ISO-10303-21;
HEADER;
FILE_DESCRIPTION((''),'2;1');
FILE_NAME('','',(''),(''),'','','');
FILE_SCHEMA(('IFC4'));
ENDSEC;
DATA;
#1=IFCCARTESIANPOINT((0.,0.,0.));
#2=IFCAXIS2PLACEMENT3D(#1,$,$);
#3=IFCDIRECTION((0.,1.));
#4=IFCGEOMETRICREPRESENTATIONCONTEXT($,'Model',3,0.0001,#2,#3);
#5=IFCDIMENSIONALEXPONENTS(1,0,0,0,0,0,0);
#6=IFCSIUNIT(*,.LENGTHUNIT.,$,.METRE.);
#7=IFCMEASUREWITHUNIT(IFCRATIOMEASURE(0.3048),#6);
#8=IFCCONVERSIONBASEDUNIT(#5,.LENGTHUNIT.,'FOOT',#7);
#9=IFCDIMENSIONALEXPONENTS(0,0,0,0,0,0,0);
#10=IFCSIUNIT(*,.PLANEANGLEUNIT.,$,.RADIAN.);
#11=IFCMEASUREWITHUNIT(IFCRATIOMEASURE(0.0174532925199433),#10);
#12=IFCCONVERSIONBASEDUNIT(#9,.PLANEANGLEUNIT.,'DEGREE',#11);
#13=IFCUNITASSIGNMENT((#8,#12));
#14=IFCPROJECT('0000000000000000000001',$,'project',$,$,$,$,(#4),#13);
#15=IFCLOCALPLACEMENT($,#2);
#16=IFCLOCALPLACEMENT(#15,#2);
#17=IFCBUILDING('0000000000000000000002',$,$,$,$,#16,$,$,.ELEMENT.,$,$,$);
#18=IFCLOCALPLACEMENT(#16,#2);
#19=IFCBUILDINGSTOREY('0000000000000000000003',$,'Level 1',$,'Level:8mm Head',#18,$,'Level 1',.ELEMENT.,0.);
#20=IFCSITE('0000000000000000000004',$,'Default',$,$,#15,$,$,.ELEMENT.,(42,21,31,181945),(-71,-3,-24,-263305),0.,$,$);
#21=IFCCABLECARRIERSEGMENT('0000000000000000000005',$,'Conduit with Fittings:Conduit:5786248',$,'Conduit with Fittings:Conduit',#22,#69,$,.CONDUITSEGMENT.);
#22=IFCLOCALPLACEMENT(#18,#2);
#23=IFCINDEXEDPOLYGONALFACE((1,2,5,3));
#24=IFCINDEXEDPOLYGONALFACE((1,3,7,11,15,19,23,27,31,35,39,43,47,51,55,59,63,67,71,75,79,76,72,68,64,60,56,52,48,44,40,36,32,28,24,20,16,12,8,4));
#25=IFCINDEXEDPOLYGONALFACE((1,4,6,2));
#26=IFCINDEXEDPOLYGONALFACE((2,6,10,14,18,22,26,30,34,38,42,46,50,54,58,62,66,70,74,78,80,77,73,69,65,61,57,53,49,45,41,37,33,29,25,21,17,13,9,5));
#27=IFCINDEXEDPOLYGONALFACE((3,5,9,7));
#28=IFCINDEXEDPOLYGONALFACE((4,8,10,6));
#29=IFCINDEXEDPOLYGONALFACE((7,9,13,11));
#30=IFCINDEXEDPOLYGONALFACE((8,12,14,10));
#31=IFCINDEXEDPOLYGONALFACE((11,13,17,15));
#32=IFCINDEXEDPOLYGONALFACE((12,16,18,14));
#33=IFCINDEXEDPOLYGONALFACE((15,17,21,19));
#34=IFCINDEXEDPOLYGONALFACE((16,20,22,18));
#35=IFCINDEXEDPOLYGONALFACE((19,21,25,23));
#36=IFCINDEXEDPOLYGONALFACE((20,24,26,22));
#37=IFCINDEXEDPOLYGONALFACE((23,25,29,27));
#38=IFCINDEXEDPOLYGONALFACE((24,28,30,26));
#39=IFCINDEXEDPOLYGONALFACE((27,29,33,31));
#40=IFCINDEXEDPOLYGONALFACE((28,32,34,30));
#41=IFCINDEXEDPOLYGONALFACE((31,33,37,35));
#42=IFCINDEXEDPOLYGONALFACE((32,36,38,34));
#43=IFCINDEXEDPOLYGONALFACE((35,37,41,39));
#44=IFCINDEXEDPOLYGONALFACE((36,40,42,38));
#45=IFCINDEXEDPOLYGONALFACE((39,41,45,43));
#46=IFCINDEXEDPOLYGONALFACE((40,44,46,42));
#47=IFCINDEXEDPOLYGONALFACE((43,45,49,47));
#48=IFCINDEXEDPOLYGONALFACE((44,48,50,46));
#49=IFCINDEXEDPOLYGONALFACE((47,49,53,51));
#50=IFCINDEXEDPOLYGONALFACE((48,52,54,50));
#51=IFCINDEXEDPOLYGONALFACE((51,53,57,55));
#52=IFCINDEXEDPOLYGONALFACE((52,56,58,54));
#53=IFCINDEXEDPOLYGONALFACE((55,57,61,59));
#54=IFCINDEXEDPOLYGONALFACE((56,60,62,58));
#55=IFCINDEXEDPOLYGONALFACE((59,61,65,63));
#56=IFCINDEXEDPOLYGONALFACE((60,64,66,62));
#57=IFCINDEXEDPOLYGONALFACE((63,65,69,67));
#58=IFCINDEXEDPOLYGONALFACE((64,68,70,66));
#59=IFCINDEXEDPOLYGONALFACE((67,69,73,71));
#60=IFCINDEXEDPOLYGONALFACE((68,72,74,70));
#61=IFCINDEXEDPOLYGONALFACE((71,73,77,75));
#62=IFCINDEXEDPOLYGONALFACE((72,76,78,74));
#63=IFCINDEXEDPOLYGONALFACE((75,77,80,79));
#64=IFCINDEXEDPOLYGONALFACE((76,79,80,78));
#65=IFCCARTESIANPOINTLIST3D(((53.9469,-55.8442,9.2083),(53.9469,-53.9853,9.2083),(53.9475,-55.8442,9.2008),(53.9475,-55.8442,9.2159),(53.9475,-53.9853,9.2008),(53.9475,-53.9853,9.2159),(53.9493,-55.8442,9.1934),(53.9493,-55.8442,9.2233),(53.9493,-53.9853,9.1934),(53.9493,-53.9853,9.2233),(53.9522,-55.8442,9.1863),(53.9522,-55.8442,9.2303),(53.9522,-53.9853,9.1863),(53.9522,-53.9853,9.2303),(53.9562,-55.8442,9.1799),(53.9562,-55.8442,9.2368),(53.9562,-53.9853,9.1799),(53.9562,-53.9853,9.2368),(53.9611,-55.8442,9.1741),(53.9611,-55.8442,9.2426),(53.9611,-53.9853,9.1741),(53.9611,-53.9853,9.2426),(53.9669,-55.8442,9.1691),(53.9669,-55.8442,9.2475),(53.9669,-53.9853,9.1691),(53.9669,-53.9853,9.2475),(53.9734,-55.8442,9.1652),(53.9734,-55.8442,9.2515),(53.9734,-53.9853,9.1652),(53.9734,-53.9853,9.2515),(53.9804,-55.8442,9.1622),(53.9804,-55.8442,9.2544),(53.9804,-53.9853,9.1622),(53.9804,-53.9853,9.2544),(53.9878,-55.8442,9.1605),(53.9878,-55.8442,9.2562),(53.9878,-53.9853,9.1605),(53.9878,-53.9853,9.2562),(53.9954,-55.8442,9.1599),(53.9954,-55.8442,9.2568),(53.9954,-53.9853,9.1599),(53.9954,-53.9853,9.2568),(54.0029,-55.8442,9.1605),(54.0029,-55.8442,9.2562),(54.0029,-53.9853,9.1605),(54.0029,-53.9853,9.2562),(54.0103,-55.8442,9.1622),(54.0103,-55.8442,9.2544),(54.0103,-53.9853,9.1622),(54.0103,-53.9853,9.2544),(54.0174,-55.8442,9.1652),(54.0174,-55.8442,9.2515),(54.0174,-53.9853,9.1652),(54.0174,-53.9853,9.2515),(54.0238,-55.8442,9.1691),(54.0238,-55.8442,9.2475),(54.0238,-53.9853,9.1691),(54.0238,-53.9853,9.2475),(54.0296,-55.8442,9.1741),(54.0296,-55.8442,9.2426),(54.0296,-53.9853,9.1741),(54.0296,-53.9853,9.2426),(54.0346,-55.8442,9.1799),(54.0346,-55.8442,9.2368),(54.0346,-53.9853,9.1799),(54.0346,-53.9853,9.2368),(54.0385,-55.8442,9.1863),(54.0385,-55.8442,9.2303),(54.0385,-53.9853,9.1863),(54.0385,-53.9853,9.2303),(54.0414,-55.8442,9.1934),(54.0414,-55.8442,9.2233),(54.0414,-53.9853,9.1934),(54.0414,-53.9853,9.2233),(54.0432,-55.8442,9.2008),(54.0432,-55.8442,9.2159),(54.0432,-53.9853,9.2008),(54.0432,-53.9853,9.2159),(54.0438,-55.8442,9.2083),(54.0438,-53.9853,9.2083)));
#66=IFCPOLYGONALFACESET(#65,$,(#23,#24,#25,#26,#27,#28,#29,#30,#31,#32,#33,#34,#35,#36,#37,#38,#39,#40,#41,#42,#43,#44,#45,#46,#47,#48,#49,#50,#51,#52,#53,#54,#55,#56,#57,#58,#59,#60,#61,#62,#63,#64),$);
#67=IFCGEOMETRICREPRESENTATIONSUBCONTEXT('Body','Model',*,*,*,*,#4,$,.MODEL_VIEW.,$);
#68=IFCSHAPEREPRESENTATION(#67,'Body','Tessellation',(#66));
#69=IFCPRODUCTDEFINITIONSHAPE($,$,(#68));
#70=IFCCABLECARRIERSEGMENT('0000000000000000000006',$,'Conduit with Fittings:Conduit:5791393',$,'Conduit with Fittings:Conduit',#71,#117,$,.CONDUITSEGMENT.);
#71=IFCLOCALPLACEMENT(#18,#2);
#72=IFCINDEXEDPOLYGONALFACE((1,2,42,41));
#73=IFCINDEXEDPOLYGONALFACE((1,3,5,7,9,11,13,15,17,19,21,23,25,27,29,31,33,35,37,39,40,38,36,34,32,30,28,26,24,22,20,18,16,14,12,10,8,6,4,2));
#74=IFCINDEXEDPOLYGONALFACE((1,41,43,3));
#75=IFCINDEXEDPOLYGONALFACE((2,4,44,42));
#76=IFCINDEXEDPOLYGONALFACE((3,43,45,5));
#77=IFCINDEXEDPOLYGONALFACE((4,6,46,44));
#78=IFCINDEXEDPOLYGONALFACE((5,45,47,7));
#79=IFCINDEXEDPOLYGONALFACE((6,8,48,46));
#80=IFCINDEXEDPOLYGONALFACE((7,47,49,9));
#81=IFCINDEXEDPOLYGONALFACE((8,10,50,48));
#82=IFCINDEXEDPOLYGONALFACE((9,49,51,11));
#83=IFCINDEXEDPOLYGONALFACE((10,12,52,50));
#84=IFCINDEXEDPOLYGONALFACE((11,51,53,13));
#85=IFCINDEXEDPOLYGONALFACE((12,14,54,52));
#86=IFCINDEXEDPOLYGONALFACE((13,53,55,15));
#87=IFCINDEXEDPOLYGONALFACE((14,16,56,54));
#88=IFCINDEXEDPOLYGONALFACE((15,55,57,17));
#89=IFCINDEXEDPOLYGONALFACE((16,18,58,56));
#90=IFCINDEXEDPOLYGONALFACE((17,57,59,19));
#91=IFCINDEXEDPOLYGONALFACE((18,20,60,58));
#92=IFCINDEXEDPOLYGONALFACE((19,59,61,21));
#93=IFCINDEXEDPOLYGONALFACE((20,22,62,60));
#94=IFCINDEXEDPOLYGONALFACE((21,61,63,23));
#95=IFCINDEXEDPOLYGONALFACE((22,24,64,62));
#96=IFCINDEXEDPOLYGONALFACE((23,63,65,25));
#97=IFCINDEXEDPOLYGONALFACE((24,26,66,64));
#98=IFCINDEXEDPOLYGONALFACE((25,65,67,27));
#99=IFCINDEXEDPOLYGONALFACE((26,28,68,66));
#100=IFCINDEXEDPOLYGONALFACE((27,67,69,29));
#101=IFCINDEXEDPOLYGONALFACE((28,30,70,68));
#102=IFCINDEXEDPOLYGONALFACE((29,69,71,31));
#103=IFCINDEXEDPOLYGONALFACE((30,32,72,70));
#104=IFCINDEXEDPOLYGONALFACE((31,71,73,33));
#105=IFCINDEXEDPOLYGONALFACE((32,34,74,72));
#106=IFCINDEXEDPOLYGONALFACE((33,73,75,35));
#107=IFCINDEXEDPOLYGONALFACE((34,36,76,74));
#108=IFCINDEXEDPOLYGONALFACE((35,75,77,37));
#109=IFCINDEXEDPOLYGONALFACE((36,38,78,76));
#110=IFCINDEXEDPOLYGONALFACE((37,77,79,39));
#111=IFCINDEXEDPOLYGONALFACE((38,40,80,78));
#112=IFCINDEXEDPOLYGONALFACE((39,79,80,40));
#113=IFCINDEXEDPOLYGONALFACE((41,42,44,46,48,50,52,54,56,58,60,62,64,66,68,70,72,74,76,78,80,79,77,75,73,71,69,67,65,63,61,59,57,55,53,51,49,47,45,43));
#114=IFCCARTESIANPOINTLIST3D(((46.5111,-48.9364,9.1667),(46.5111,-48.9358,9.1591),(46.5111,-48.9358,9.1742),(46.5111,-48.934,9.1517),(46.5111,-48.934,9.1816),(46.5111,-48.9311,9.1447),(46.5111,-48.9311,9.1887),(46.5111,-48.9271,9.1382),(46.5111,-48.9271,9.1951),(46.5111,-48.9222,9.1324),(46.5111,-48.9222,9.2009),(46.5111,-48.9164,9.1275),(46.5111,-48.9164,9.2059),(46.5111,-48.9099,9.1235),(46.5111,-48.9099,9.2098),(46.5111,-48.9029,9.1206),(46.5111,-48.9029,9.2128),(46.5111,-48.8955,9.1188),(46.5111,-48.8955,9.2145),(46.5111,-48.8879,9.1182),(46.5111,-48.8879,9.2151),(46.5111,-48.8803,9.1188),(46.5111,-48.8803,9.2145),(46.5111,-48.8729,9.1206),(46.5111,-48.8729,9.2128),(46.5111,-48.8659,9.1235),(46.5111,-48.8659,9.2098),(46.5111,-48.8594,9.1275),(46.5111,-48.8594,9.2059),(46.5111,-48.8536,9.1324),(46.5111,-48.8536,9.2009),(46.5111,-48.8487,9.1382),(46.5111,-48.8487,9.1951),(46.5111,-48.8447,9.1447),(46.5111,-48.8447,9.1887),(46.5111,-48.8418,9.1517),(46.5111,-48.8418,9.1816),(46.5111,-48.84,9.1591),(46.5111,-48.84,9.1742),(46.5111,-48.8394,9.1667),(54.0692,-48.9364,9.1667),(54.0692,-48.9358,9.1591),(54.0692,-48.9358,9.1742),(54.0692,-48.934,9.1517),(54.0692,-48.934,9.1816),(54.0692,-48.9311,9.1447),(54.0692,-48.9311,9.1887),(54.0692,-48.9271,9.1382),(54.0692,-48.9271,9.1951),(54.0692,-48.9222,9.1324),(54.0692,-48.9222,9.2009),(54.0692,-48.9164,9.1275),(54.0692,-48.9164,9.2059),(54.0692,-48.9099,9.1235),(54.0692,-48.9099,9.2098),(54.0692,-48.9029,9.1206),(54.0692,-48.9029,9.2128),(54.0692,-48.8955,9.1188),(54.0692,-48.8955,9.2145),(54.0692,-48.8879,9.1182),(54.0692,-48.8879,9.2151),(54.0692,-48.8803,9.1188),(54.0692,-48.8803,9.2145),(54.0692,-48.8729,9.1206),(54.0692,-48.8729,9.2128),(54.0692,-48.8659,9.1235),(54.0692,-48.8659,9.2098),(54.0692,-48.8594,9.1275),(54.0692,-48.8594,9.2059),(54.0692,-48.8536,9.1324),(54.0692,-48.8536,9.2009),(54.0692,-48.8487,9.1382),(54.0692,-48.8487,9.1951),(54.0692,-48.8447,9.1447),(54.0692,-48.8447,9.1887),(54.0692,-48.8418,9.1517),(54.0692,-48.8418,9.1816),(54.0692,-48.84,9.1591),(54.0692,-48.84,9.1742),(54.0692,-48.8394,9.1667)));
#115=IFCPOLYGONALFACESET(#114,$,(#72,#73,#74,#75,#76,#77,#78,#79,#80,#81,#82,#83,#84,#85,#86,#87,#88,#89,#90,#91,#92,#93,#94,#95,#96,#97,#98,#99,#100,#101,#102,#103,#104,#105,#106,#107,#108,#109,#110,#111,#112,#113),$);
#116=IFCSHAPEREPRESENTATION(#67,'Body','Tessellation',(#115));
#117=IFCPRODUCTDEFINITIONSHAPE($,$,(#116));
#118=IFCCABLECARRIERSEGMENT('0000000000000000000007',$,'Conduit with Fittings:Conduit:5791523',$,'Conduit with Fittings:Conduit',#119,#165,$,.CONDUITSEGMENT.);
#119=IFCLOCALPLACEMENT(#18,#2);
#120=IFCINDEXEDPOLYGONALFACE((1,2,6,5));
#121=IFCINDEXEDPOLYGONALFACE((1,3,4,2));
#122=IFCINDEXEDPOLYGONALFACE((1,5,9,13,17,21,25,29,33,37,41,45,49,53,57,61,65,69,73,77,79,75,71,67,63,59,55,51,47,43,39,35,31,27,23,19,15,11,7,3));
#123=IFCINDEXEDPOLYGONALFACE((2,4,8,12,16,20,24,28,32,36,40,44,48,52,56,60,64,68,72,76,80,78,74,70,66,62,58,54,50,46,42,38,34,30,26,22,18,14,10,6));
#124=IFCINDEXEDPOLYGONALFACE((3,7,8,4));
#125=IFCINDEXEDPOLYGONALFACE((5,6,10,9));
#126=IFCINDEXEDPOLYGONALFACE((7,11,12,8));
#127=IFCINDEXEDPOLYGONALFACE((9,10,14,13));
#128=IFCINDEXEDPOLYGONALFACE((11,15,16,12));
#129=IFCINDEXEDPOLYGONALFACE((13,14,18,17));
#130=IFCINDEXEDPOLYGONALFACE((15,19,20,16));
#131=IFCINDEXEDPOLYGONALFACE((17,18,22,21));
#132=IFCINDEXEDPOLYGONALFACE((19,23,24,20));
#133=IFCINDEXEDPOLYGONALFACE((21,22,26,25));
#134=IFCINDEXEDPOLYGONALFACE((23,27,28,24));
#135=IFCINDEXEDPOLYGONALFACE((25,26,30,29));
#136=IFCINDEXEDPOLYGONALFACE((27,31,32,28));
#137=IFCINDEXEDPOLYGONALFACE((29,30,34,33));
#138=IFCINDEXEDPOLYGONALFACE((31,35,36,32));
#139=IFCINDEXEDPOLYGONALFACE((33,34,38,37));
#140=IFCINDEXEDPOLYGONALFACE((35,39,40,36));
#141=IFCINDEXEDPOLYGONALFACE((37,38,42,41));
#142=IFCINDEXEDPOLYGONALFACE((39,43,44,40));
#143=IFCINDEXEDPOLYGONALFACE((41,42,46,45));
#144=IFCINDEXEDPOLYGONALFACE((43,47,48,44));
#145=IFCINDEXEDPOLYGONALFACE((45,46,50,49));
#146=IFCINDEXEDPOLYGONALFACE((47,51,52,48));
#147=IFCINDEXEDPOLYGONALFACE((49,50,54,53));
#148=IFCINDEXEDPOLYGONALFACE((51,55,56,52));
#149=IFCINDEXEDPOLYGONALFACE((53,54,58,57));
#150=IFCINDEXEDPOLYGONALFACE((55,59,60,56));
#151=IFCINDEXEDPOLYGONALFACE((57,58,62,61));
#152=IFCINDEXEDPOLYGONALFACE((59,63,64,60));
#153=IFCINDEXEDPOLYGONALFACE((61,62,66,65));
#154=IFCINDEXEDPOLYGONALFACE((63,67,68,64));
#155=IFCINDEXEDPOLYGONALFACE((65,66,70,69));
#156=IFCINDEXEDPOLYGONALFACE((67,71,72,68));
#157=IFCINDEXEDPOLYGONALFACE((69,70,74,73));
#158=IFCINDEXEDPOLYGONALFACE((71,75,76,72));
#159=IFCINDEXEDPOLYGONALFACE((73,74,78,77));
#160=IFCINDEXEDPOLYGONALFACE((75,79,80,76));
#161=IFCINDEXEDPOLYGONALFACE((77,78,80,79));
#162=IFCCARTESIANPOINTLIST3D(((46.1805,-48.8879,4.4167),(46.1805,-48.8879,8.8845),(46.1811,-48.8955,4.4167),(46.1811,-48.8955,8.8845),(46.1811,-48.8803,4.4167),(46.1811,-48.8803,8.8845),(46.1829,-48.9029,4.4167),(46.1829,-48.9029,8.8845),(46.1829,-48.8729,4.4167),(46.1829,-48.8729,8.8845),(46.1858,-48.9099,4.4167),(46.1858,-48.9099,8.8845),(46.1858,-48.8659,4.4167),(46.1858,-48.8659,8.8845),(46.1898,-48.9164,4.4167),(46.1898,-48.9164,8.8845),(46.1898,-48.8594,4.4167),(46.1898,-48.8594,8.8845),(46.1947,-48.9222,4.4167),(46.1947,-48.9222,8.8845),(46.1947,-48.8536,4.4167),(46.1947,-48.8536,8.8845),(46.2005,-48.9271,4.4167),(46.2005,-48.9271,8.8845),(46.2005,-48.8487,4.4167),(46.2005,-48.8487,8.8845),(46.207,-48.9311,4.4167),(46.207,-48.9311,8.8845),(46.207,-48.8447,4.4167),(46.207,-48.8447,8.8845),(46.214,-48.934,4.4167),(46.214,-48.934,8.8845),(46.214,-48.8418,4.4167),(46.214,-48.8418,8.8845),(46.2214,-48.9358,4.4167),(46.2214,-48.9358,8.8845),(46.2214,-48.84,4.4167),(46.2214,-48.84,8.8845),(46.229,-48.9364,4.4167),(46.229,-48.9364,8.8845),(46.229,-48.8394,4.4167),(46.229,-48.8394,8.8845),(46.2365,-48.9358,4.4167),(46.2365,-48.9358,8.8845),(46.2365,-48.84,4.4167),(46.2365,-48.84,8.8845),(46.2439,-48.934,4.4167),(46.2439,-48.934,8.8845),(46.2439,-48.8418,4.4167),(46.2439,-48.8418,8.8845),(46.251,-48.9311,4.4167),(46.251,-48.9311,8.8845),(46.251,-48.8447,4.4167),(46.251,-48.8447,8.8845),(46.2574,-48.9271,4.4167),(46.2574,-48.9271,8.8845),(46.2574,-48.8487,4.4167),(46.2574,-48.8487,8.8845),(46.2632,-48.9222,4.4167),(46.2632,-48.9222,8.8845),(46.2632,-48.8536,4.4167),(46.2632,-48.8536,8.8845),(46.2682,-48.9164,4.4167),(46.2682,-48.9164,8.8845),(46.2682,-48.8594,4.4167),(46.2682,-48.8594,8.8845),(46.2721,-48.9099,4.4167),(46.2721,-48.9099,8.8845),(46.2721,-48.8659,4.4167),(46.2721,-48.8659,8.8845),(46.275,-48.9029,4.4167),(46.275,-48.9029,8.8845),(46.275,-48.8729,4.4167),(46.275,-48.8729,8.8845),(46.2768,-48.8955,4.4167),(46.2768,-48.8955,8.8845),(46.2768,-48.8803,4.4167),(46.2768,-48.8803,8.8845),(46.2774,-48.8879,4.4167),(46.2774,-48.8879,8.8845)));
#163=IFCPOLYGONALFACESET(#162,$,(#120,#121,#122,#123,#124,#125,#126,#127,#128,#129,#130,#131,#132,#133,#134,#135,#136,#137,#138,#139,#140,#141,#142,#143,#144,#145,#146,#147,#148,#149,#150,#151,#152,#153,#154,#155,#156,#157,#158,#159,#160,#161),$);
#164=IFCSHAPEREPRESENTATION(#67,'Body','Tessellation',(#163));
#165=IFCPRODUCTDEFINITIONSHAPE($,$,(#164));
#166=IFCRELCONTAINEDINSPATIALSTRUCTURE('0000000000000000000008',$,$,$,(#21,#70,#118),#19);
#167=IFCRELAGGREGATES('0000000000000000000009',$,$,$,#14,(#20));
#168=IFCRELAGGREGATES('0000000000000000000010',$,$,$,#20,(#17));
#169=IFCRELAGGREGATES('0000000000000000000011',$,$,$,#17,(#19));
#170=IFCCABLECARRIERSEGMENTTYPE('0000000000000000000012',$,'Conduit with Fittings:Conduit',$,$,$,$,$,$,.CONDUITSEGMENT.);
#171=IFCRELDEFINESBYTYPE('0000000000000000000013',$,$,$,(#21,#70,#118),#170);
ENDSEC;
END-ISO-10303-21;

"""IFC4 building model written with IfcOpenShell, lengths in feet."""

from ifc_helpers import new_model, entity, si_unit, converted_unit, direction, frame, origin, place, context, subcontext, project, spatial, indexed_curve, outline, extrude, type_object, element, save


model = new_model("IFC4")

# Units and contexts
model_context = context("Model", 3, precision=0.0001, world=origin(), true_north=direction((0.0, 1.0)))
body_context = subcontext(model_context, "Body", "Model", "MODEL_VIEW")
ifc_project = project(units=[converted_unit("LENGTHUNIT", "FOOT", entity("IfcRatioMeasure", 0.3048), si_unit("LENGTHUNIT", "METRE"), dimensions=[1, 0, 0, 0, 0, 0, 0]), converted_unit("PLANEANGLEUNIT", "DEGREE", entity("IfcRatioMeasure", 0.0174532925199433), si_unit("PLANEANGLEUNIT", "RADIAN"), dimensions=[0, 0, 0, 0, 0, 0, 0])], contexts=[model_context])

# Site, building, storey
site_placement = place(None, origin())
site = spatial("IfcSite", under=ifc_project, at=site_placement, Name="Default", CompositionType="ELEMENT", RefLatitude=(42, 21, 31, 181945), RefLongitude=(-71, -3, -24, -263305), RefElevation=0.0)
building_placement = place(site_placement, origin())
building = spatial("IfcBuilding", under=site, at=building_placement, CompositionType="ELEMENT")
storey_placement = place(building_placement, origin())
storey = spatial("IfcBuildingStorey", under=building, at=storey_placement, Name="Level 1", ObjectType="Level:8mm Head", LongName="Level 1", CompositionType="ELEMENT", Elevation=0.0)

# Cable carrier segments
cable_carrier_segment_type_1 = type_object("IfcCableCarrierSegmentType", Name="Conduit with Fittings:Conduit", PredefinedType="CONDUITSEGMENT")
cable_carrier_segment_1_placement = place(storey_placement, origin())
element("IfcCableCarrierSegment", 1, at=cable_carrier_segment_1_placement, inside=storey, type_object=cable_carrier_segment_type_1, Name="Conduit with Fittings:Conduit:5786248", ObjectType="Conduit with Fittings:Conduit", PredefinedType="CONDUITSEGMENT", context=body_context, shape_type="SweptSolid", body=[
    extrude(outline(indexed_curve([(0.0485, 0.0), (0.0479, 0.0076), (0.0461, 0.015), (0.0432, 0.022), (0.0392, 0.0285), (0.0343, 0.0343), (0.0285, 0.0392), (0.022, 0.0432), (0.015, 0.0461), (0.0076, 0.0479), (0.0, 0.0485), (-0.0076, 0.0479), (-0.015, 0.0461), (-0.022, 0.0432), (-0.0285, 0.0392), (-0.0343, 0.0343), (-0.0392, 0.0285), (-0.0432, 0.022), (-0.0461, 0.015), (-0.0479, 0.0076), (-0.0485, 0.0), (-0.0479, -0.0076), (-0.0461, -0.015), (-0.0432, -0.022), (-0.0392, -0.0285), (-0.0343, -0.0343), (-0.0285, -0.0392), (-0.022, -0.0432), (-0.015, -0.0461), (-0.0076, -0.0479), (0.0, -0.0485), (0.0076, -0.0479), (0.015, -0.0461), (0.022, -0.0432), (0.0285, -0.0392), (0.0343, -0.0343), (0.0392, -0.0285), (0.0432, -0.022), (0.0461, -0.015), (0.0479, -0.0076), (0.0485, 0.0)], self_intersect=False)), frame((53.9954, -55.8442, 9.2083), z_axis=(0.0, 1.0, 0.0), x_axis=(1.0, 0.0, 0.0)), (0.0, 0.0, 1.0), 1.8589),
])
cable_carrier_segment_2_placement = place(storey_placement, origin())
element("IfcCableCarrierSegment", 2, at=cable_carrier_segment_2_placement, inside=storey, type_object=cable_carrier_segment_type_1, Name="Conduit with Fittings:Conduit:5791393", ObjectType="Conduit with Fittings:Conduit", PredefinedType="CONDUITSEGMENT", context=body_context, shape_type="SweptSolid", body=[
    extrude(outline(indexed_curve([(0.0485, 0.0), (0.0479, 0.0076), (0.0461, 0.015), (0.0432, 0.022), (0.0392, 0.0285), (0.0343, 0.0343), (0.0285, 0.0392), (0.022, 0.0432), (0.015, 0.0461), (0.0076, 0.0479), (0.0, 0.0485), (-0.0076, 0.0479), (-0.015, 0.0461), (-0.022, 0.0432), (-0.0285, 0.0392), (-0.0343, 0.0343), (-0.0392, 0.0285), (-0.0432, 0.022), (-0.0461, 0.015), (-0.0479, 0.0076), (-0.0485, 0.0), (-0.0479, -0.0076), (-0.0461, -0.015), (-0.0432, -0.022), (-0.0392, -0.0285), (-0.0343, -0.0343), (-0.0285, -0.0392), (-0.022, -0.0432), (-0.015, -0.0461), (-0.0076, -0.0479), (0.0, -0.0485), (0.0076, -0.0479), (0.015, -0.0461), (0.022, -0.0432), (0.0285, -0.0392), (0.0343, -0.0343), (0.0392, -0.0285), (0.0432, -0.022), (0.0461, -0.015), (0.0479, -0.0076), (0.0485, 0.0)], self_intersect=False)), frame((46.5111, -48.8879, 9.1667), z_axis=(1.0, 0.0, 0.0), x_axis=(0.0, -1.0, 0.0)), (0.0, 0.0, 1.0), 7.5581),
])
cable_carrier_segment_3_placement = place(storey_placement, origin())
element("IfcCableCarrierSegment", 3, at=cable_carrier_segment_3_placement, inside=storey, type_object=cable_carrier_segment_type_1, Name="Conduit with Fittings:Conduit:5791523", ObjectType="Conduit with Fittings:Conduit", PredefinedType="CONDUITSEGMENT", context=body_context, shape_type="SweptSolid", body=[
    extrude(outline(indexed_curve([(0.0485, 0.0), (0.0479, 0.0076), (0.0461, 0.015), (0.0432, 0.022), (0.0392, 0.0285), (0.0343, 0.0343), (0.0285, 0.0392), (0.022, 0.0432), (0.015, 0.0461), (0.0076, 0.0479), (0.0, 0.0485), (-0.0076, 0.0479), (-0.015, 0.0461), (-0.022, 0.0432), (-0.0285, 0.0392), (-0.0343, 0.0343), (-0.0392, 0.0285), (-0.0432, 0.022), (-0.0461, 0.015), (-0.0479, 0.0076), (-0.0485, 0.0), (-0.0479, -0.0076), (-0.0461, -0.015), (-0.0432, -0.022), (-0.0392, -0.0285), (-0.0343, -0.0343), (-0.0285, -0.0392), (-0.022, -0.0432), (-0.015, -0.0461), (-0.0076, -0.0479), (0.0, -0.0485), (0.0076, -0.0479), (0.015, -0.0461), (0.022, -0.0432), (0.0285, -0.0392), (0.0343, -0.0343), (0.0392, -0.0285), (0.0432, -0.022), (0.0461, -0.015), (0.0479, -0.0076), (0.0485, 0.0)], self_intersect=False)), frame((46.229, -48.8879, 4.4167)), (0.0, 0.0, 1.0), 4.4678),
])

save(model, "model.ifc")
